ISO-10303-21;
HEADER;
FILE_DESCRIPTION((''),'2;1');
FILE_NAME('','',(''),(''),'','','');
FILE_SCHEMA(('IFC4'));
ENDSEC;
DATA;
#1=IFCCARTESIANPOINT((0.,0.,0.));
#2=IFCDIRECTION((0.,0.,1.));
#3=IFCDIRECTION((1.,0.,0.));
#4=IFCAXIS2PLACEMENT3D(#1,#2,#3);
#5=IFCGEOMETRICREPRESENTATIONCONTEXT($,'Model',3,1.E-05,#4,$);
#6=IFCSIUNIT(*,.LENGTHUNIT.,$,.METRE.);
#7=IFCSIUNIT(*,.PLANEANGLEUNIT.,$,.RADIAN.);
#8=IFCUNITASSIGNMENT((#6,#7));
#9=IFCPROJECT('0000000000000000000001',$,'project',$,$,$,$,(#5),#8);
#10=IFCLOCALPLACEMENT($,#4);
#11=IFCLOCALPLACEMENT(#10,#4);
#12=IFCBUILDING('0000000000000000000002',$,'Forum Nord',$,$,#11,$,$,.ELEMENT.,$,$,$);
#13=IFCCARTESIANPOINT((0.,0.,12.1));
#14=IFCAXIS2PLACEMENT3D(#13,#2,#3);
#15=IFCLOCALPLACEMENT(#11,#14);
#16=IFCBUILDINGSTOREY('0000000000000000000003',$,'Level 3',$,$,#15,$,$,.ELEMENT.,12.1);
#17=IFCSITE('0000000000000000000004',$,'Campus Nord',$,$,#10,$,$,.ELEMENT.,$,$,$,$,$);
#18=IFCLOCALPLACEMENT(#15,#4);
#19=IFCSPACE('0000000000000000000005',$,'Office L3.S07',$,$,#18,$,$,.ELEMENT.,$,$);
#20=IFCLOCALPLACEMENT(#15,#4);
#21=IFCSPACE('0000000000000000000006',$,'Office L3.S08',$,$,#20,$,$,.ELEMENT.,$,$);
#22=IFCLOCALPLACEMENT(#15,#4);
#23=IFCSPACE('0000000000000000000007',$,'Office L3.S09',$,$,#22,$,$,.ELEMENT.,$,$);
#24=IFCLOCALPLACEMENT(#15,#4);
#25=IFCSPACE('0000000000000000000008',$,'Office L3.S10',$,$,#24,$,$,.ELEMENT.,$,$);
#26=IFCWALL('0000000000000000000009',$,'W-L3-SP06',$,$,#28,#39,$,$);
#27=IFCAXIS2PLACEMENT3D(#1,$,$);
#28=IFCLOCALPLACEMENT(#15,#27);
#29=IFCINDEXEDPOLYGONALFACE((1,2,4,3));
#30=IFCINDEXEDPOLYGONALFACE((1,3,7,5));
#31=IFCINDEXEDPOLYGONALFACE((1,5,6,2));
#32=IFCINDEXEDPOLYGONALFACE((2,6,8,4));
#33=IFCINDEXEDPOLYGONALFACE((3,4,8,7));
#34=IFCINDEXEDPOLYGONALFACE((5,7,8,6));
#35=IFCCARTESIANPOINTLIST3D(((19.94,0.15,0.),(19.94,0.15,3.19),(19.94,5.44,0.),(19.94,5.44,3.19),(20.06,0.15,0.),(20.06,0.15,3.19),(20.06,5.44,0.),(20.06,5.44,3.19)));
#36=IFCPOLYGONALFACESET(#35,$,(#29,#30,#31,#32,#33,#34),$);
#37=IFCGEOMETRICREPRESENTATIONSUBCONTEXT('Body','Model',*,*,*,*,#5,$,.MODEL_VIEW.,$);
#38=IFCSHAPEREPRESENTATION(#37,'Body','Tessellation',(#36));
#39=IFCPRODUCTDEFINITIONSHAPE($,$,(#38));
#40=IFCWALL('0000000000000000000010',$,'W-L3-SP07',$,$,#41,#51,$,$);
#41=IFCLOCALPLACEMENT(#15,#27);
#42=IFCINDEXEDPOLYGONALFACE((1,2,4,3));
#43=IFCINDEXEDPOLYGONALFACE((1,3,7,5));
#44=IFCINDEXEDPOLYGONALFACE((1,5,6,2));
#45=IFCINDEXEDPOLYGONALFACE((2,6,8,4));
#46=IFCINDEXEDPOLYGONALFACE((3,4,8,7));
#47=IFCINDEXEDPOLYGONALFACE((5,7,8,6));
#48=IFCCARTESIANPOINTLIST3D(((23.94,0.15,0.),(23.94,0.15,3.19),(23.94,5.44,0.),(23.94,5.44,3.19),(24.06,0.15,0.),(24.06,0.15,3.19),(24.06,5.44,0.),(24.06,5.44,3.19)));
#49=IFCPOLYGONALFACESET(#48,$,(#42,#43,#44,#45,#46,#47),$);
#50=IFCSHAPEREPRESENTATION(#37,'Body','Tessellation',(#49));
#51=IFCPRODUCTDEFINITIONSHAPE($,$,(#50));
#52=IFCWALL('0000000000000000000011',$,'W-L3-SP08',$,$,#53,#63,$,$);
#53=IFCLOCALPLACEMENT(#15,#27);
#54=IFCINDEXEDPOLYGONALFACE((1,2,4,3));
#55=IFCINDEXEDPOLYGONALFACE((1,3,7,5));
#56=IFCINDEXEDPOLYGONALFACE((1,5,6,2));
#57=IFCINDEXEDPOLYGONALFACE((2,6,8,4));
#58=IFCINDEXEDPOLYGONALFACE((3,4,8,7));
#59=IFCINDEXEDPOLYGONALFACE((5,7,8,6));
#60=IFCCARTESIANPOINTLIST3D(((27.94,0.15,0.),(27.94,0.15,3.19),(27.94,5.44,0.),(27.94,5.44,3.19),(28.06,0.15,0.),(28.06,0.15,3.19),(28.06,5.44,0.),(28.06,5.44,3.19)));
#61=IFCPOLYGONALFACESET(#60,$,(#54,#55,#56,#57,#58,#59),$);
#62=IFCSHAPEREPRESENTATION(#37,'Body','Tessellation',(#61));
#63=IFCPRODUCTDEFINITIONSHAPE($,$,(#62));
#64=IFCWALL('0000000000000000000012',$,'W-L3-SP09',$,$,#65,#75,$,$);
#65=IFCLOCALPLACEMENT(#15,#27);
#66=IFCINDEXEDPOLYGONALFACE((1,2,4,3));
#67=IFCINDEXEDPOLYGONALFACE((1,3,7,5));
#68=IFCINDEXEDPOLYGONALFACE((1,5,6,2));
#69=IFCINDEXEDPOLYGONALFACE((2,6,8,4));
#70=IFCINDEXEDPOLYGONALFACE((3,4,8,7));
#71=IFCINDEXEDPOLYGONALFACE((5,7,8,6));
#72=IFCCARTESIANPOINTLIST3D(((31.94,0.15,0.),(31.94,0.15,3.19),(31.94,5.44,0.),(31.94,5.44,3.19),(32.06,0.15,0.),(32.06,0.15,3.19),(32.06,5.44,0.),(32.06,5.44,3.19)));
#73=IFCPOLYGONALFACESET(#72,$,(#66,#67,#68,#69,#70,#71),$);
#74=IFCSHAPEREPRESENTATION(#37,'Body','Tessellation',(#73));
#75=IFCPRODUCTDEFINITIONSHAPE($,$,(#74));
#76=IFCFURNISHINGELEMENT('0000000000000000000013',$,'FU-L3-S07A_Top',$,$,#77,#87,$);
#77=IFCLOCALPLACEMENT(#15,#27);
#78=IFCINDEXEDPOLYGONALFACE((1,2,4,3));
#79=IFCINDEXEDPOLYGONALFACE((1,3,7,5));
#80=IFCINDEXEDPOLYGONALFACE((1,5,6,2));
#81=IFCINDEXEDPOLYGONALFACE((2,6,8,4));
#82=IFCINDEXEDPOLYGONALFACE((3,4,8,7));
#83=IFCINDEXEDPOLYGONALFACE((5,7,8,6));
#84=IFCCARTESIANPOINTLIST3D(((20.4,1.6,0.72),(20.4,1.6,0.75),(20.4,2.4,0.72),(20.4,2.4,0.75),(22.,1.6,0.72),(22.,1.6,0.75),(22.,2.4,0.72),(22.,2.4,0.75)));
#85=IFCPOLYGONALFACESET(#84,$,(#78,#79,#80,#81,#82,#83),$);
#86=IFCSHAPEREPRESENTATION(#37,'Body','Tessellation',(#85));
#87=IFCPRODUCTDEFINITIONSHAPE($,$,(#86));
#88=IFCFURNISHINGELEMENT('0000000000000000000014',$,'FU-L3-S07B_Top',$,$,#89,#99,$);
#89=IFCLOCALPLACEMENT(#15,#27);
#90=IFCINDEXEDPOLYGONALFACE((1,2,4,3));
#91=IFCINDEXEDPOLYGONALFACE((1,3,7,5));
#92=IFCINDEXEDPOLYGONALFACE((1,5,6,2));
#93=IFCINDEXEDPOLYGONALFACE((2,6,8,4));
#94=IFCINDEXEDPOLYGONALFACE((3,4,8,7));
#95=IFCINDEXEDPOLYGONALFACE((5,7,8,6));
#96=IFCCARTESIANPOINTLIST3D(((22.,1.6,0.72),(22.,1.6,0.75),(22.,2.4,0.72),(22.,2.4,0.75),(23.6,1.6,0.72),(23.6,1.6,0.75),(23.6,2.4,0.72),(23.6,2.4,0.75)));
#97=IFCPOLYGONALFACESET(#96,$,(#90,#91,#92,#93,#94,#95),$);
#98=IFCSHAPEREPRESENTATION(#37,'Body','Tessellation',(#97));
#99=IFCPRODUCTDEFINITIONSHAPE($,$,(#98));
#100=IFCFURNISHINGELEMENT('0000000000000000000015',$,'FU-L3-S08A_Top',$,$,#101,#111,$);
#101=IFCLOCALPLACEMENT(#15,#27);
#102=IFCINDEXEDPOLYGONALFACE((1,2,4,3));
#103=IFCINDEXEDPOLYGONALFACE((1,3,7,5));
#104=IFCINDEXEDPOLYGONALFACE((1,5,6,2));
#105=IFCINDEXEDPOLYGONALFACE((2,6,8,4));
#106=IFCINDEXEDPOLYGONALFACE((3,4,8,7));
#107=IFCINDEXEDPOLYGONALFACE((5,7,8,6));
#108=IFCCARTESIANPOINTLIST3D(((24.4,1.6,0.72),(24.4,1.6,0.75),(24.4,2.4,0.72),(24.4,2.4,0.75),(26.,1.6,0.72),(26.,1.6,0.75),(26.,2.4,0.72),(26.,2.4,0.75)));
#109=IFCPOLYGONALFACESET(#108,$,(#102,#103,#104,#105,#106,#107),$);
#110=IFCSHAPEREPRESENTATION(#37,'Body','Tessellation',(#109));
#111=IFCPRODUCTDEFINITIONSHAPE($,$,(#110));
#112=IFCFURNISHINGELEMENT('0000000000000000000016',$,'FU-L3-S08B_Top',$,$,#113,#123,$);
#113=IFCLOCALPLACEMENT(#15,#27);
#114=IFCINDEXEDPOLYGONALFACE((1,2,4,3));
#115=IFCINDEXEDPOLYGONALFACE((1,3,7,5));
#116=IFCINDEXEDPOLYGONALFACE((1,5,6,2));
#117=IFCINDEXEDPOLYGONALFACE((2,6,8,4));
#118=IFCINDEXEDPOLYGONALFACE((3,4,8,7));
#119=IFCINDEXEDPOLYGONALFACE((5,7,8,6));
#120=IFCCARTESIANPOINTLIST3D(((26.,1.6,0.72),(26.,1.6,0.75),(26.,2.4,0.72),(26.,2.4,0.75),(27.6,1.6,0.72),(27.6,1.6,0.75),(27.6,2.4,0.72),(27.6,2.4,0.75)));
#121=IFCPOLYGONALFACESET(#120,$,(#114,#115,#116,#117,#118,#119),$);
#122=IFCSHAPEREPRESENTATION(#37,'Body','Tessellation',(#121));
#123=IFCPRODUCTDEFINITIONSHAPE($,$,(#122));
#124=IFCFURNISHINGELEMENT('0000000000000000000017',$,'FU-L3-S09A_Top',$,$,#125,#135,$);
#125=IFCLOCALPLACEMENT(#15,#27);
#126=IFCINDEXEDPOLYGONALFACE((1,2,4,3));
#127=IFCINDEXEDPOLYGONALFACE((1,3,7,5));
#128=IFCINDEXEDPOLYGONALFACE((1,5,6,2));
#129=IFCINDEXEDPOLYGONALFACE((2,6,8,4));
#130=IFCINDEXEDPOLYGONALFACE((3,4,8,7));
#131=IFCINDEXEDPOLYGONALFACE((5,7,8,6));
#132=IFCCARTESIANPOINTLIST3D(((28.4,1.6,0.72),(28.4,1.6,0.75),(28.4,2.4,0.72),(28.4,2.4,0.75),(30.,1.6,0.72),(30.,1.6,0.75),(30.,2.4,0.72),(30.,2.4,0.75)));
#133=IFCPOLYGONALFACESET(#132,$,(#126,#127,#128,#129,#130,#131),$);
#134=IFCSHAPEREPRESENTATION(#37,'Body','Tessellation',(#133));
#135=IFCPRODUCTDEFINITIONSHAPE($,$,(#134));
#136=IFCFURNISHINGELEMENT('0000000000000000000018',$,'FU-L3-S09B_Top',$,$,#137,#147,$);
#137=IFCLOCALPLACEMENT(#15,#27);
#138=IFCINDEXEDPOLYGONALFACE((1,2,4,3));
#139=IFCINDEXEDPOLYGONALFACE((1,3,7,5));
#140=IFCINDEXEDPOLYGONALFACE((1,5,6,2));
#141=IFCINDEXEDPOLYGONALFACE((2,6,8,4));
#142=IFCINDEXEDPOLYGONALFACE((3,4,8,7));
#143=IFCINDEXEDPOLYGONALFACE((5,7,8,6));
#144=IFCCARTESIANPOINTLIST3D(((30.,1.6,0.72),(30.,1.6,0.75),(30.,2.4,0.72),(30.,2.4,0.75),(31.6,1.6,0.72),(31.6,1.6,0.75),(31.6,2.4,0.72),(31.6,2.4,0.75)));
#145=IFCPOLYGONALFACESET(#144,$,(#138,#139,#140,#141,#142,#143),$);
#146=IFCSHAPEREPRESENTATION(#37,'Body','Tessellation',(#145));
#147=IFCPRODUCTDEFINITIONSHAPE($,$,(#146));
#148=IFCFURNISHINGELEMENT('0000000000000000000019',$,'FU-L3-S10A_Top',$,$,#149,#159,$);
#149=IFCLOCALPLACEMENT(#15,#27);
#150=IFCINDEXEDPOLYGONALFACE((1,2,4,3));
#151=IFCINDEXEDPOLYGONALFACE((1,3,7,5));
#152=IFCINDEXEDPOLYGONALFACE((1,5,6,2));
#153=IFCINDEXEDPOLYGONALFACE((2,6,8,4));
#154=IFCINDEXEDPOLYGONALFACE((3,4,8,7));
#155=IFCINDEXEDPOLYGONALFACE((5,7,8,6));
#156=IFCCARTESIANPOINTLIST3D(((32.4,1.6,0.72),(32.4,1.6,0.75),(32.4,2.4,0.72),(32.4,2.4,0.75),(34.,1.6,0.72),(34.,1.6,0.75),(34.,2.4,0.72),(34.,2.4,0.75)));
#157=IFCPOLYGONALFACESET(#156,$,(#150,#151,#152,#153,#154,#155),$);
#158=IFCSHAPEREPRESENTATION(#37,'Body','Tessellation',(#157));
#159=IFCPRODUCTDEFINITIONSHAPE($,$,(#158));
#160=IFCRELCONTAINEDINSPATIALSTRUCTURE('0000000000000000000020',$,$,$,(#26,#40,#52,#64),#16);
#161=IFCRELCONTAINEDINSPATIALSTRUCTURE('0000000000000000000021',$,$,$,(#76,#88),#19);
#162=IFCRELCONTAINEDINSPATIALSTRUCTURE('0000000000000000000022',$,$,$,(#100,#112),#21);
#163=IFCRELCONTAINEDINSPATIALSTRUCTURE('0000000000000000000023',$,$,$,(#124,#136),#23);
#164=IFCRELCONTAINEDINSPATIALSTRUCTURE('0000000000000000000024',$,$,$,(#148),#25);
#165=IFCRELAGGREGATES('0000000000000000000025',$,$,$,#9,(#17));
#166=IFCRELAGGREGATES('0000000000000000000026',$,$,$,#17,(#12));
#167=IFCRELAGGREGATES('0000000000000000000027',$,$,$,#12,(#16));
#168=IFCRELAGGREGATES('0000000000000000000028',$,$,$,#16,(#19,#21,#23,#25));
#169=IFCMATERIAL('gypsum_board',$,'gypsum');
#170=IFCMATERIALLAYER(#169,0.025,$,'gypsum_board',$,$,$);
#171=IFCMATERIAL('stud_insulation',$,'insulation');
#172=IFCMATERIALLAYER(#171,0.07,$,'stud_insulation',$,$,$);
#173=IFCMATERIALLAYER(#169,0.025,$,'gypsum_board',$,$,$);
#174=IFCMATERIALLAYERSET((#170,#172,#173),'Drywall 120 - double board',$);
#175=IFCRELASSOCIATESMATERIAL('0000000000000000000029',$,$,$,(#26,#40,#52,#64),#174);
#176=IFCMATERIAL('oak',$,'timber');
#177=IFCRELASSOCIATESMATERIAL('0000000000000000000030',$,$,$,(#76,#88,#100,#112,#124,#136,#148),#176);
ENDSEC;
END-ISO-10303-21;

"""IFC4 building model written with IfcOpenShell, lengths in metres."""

from ifc_helpers import new_model, si_unit, frame, frame_2d, origin_with_axes, place, context, subcontext, project, spatial, polyline, rectangle, outline, extrude, material, layer, layer_set, layer_usage, element, save


model = new_model("IFC4")

# Units and contexts
model_context = context("Model", 3, precision=1e-05, world=origin_with_axes())
body_context = subcontext(model_context, "Body", "Model", "MODEL_VIEW")
ifc_project = project(units=[si_unit("LENGTHUNIT", "METRE"), si_unit("PLANEANGLEUNIT", "RADIAN")], contexts=[model_context])

# Site, building, storey
site_placement = place(None, origin_with_axes())
site = spatial("IfcSite", under=ifc_project, at=site_placement, Name="Campus Nord", CompositionType="ELEMENT")
building_placement = place(site_placement, origin_with_axes())
building = spatial("IfcBuilding", under=site, at=building_placement, Name="Forum Nord", CompositionType="ELEMENT")
storey_placement = place(building_placement, frame((0.0, 0.0, 12.1), z_axis=(0.0, 0.0, 1.0), x_axis=(1.0, 0.0, 0.0)))
storey = spatial("IfcBuildingStorey", under=building, at=storey_placement, Name="Level 3", CompositionType="ELEMENT", Elevation=12.1)

# Walls
ifc_material_1 = material(Name="gypsum_board", Category="gypsum")
ifc_layer_1 = layer(ifc_material_1, 0.025, Name="gypsum_board")
ifc_material_2 = material(Name="stud_insulation", Category="insulation")
ifc_layer_2 = layer(ifc_material_2, 0.07, Name="stud_insulation")
ifc_layer_3 = layer(ifc_material_1, 0.025, Name="gypsum_board")
ifc_layer_set = layer_set([ifc_layer_1, ifc_layer_2, ifc_layer_3], Name="Drywall 120 - double board")
ifc_layer_usage = layer_usage(ifc_layer_set, "AXIS2", "POSITIVE", -0.06)
for number, where, z_axis, x_axis, name in (
    (1, (20.0, 0.15, 0.0), (0.0, 0.0, 1.0), (0.0, 1.0, 0.0), "W-L3-SP06"),
    (2, (24.0, 0.15, 0.0), (0.0, 0.0, 1.0), (0.0, 1.0, 0.0), "W-L3-SP07"),
    (3, (28.0, 0.15, 0.0), (0.0, 0.0, 1.0), (0.0, 1.0, 0.0), "W-L3-SP08"),
    (4, (32.0, 0.15, 0.0), (0.0, 0.0, 1.0), (0.0, 1.0, 0.0), "W-L3-SP09"),
):
    element("IfcWall", number, at=place(storey_placement, frame(where, z_axis=z_axis, x_axis=x_axis)), inside=storey, material=ifc_layer_usage, Name=name, context=body_context, shape_type="SweptSolid", body=[
        extrude(outline(polyline([(0.0, -0.06), (5.29, -0.06), (5.29, 0.06), (0.0, 0.06), (0.0, -0.06)])), origin_with_axes(), (0.0, 0.0, 1.0), 3.19),
    ])

# Shared definitions
space_1_placement = place(storey_placement, origin_with_axes())
space_1 = spatial("IfcSpace", under=storey, at=space_1_placement, Name="Office L3.S07", CompositionType="ELEMENT")

# Furnishing elements
ifc_material_3 = material(Name="oak", Category="timber")
furnishing_1_placement = place(storey_placement, frame((20.4, 1.0, 0.0), z_axis=(0.0, 0.0, 1.0), x_axis=(1.0, 0.0, 0.0)))
element("IfcFurnishingElement", 5, at=furnishing_1_placement, inside=space_1, material=ifc_material_3, Name="FU-L3-S07A_Top", context=body_context, shape_type="SweptSolid", body=[
    extrude(rectangle(XDim=1.6, YDim=0.8, at=frame_2d((0.8, 1.0), x_axis=(1.0, 0.0))), frame((0.0, 0.0, 0.72), z_axis=(0.0, 0.0, 1.0), x_axis=(1.0, 0.0, 0.0)), (0.0, 0.0, 1.0), 0.03),
])
furnishing_2_placement = place(storey_placement, frame((22.0, 1.0, 0.0), z_axis=(0.0, 0.0, 1.0), x_axis=(1.0, 0.0, 0.0)))
element("IfcFurnishingElement", 6, at=furnishing_2_placement, inside=space_1, material=ifc_material_3, Name="FU-L3-S07B_Top", context=body_context, shape_type="SweptSolid", body=[
    extrude(rectangle(XDim=1.6, YDim=0.8, at=frame_2d((0.8, 1.0), x_axis=(1.0, 0.0))), frame((0.0, 0.0, 0.72), z_axis=(0.0, 0.0, 1.0), x_axis=(1.0, 0.0, 0.0)), (0.0, 0.0, 1.0), 0.03),
])

# Shared definitions
space_2_placement = place(storey_placement, origin_with_axes())
space_2 = spatial("IfcSpace", under=storey, at=space_2_placement, Name="Office L3.S08", CompositionType="ELEMENT")

# Furnishing elements
furnishing_3_placement = place(storey_placement, frame((24.4, 1.0, 0.0), z_axis=(0.0, 0.0, 1.0), x_axis=(1.0, 0.0, 0.0)))
element("IfcFurnishingElement", 7, at=furnishing_3_placement, inside=space_2, material=ifc_material_3, Name="FU-L3-S08A_Top", context=body_context, shape_type="SweptSolid", body=[
    extrude(rectangle(XDim=1.6, YDim=0.8, at=frame_2d((0.8, 1.0), x_axis=(1.0, 0.0))), frame((0.0, 0.0, 0.72), z_axis=(0.0, 0.0, 1.0), x_axis=(1.0, 0.0, 0.0)), (0.0, 0.0, 1.0), 0.03),
])
furnishing_4_placement = place(storey_placement, frame((26.0, 1.0, 0.0), z_axis=(0.0, 0.0, 1.0), x_axis=(1.0, 0.0, 0.0)))
element("IfcFurnishingElement", 8, at=furnishing_4_placement, inside=space_2, material=ifc_material_3, Name="FU-L3-S08B_Top", context=body_context, shape_type="SweptSolid", body=[
    extrude(rectangle(XDim=1.6, YDim=0.8, at=frame_2d((0.8, 1.0), x_axis=(1.0, 0.0))), frame((0.0, 0.0, 0.72), z_axis=(0.0, 0.0, 1.0), x_axis=(1.0, 0.0, 0.0)), (0.0, 0.0, 1.0), 0.03),
])

# Shared definitions
space_3_placement = place(storey_placement, origin_with_axes())
space_3 = spatial("IfcSpace", under=storey, at=space_3_placement, Name="Office L3.S09", CompositionType="ELEMENT")

# Furnishing elements
furnishing_5_placement = place(storey_placement, frame((28.4, 1.0, 0.0), z_axis=(0.0, 0.0, 1.0), x_axis=(1.0, 0.0, 0.0)))
element("IfcFurnishingElement", 9, at=furnishing_5_placement, inside=space_3, material=ifc_material_3, Name="FU-L3-S09A_Top", context=body_context, shape_type="SweptSolid", body=[
    extrude(rectangle(XDim=1.6, YDim=0.8, at=frame_2d((0.8, 1.0), x_axis=(1.0, 0.0))), frame((0.0, 0.0, 0.72), z_axis=(0.0, 0.0, 1.0), x_axis=(1.0, 0.0, 0.0)), (0.0, 0.0, 1.0), 0.03),
])
furnishing_6_placement = place(storey_placement, frame((30.0, 1.0, 0.0), z_axis=(0.0, 0.0, 1.0), x_axis=(1.0, 0.0, 0.0)))
element("IfcFurnishingElement", 10, at=furnishing_6_placement, inside=space_3, material=ifc_material_3, Name="FU-L3-S09B_Top", context=body_context, shape_type="SweptSolid", body=[
    extrude(rectangle(XDim=1.6, YDim=0.8, at=frame_2d((0.8, 1.0), x_axis=(1.0, 0.0))), frame((0.0, 0.0, 0.72), z_axis=(0.0, 0.0, 1.0), x_axis=(1.0, 0.0, 0.0)), (0.0, 0.0, 1.0), 0.03),
])

# Shared definitions
space_4_placement = place(storey_placement, origin_with_axes())
space_4 = spatial("IfcSpace", under=storey, at=space_4_placement, Name="Office L3.S10", CompositionType="ELEMENT")

# Furnishing element
furnishing_7_placement = place(storey_placement, frame((32.4, 1.0, 0.0), z_axis=(0.0, 0.0, 1.0), x_axis=(1.0, 0.0, 0.0)))
element("IfcFurnishingElement", 11, at=furnishing_7_placement, inside=space_4, material=ifc_material_3, Name="FU-L3-S10A_Top", context=body_context, shape_type="SweptSolid", body=[
    extrude(rectangle(XDim=1.6, YDim=0.8, at=frame_2d((0.8, 1.0), x_axis=(1.0, 0.0))), frame((0.0, 0.0, 0.72), z_axis=(0.0, 0.0, 1.0), x_axis=(1.0, 0.0, 0.0)), (0.0, 0.0, 1.0), 0.03),
])

save(model, "model.ifc")
